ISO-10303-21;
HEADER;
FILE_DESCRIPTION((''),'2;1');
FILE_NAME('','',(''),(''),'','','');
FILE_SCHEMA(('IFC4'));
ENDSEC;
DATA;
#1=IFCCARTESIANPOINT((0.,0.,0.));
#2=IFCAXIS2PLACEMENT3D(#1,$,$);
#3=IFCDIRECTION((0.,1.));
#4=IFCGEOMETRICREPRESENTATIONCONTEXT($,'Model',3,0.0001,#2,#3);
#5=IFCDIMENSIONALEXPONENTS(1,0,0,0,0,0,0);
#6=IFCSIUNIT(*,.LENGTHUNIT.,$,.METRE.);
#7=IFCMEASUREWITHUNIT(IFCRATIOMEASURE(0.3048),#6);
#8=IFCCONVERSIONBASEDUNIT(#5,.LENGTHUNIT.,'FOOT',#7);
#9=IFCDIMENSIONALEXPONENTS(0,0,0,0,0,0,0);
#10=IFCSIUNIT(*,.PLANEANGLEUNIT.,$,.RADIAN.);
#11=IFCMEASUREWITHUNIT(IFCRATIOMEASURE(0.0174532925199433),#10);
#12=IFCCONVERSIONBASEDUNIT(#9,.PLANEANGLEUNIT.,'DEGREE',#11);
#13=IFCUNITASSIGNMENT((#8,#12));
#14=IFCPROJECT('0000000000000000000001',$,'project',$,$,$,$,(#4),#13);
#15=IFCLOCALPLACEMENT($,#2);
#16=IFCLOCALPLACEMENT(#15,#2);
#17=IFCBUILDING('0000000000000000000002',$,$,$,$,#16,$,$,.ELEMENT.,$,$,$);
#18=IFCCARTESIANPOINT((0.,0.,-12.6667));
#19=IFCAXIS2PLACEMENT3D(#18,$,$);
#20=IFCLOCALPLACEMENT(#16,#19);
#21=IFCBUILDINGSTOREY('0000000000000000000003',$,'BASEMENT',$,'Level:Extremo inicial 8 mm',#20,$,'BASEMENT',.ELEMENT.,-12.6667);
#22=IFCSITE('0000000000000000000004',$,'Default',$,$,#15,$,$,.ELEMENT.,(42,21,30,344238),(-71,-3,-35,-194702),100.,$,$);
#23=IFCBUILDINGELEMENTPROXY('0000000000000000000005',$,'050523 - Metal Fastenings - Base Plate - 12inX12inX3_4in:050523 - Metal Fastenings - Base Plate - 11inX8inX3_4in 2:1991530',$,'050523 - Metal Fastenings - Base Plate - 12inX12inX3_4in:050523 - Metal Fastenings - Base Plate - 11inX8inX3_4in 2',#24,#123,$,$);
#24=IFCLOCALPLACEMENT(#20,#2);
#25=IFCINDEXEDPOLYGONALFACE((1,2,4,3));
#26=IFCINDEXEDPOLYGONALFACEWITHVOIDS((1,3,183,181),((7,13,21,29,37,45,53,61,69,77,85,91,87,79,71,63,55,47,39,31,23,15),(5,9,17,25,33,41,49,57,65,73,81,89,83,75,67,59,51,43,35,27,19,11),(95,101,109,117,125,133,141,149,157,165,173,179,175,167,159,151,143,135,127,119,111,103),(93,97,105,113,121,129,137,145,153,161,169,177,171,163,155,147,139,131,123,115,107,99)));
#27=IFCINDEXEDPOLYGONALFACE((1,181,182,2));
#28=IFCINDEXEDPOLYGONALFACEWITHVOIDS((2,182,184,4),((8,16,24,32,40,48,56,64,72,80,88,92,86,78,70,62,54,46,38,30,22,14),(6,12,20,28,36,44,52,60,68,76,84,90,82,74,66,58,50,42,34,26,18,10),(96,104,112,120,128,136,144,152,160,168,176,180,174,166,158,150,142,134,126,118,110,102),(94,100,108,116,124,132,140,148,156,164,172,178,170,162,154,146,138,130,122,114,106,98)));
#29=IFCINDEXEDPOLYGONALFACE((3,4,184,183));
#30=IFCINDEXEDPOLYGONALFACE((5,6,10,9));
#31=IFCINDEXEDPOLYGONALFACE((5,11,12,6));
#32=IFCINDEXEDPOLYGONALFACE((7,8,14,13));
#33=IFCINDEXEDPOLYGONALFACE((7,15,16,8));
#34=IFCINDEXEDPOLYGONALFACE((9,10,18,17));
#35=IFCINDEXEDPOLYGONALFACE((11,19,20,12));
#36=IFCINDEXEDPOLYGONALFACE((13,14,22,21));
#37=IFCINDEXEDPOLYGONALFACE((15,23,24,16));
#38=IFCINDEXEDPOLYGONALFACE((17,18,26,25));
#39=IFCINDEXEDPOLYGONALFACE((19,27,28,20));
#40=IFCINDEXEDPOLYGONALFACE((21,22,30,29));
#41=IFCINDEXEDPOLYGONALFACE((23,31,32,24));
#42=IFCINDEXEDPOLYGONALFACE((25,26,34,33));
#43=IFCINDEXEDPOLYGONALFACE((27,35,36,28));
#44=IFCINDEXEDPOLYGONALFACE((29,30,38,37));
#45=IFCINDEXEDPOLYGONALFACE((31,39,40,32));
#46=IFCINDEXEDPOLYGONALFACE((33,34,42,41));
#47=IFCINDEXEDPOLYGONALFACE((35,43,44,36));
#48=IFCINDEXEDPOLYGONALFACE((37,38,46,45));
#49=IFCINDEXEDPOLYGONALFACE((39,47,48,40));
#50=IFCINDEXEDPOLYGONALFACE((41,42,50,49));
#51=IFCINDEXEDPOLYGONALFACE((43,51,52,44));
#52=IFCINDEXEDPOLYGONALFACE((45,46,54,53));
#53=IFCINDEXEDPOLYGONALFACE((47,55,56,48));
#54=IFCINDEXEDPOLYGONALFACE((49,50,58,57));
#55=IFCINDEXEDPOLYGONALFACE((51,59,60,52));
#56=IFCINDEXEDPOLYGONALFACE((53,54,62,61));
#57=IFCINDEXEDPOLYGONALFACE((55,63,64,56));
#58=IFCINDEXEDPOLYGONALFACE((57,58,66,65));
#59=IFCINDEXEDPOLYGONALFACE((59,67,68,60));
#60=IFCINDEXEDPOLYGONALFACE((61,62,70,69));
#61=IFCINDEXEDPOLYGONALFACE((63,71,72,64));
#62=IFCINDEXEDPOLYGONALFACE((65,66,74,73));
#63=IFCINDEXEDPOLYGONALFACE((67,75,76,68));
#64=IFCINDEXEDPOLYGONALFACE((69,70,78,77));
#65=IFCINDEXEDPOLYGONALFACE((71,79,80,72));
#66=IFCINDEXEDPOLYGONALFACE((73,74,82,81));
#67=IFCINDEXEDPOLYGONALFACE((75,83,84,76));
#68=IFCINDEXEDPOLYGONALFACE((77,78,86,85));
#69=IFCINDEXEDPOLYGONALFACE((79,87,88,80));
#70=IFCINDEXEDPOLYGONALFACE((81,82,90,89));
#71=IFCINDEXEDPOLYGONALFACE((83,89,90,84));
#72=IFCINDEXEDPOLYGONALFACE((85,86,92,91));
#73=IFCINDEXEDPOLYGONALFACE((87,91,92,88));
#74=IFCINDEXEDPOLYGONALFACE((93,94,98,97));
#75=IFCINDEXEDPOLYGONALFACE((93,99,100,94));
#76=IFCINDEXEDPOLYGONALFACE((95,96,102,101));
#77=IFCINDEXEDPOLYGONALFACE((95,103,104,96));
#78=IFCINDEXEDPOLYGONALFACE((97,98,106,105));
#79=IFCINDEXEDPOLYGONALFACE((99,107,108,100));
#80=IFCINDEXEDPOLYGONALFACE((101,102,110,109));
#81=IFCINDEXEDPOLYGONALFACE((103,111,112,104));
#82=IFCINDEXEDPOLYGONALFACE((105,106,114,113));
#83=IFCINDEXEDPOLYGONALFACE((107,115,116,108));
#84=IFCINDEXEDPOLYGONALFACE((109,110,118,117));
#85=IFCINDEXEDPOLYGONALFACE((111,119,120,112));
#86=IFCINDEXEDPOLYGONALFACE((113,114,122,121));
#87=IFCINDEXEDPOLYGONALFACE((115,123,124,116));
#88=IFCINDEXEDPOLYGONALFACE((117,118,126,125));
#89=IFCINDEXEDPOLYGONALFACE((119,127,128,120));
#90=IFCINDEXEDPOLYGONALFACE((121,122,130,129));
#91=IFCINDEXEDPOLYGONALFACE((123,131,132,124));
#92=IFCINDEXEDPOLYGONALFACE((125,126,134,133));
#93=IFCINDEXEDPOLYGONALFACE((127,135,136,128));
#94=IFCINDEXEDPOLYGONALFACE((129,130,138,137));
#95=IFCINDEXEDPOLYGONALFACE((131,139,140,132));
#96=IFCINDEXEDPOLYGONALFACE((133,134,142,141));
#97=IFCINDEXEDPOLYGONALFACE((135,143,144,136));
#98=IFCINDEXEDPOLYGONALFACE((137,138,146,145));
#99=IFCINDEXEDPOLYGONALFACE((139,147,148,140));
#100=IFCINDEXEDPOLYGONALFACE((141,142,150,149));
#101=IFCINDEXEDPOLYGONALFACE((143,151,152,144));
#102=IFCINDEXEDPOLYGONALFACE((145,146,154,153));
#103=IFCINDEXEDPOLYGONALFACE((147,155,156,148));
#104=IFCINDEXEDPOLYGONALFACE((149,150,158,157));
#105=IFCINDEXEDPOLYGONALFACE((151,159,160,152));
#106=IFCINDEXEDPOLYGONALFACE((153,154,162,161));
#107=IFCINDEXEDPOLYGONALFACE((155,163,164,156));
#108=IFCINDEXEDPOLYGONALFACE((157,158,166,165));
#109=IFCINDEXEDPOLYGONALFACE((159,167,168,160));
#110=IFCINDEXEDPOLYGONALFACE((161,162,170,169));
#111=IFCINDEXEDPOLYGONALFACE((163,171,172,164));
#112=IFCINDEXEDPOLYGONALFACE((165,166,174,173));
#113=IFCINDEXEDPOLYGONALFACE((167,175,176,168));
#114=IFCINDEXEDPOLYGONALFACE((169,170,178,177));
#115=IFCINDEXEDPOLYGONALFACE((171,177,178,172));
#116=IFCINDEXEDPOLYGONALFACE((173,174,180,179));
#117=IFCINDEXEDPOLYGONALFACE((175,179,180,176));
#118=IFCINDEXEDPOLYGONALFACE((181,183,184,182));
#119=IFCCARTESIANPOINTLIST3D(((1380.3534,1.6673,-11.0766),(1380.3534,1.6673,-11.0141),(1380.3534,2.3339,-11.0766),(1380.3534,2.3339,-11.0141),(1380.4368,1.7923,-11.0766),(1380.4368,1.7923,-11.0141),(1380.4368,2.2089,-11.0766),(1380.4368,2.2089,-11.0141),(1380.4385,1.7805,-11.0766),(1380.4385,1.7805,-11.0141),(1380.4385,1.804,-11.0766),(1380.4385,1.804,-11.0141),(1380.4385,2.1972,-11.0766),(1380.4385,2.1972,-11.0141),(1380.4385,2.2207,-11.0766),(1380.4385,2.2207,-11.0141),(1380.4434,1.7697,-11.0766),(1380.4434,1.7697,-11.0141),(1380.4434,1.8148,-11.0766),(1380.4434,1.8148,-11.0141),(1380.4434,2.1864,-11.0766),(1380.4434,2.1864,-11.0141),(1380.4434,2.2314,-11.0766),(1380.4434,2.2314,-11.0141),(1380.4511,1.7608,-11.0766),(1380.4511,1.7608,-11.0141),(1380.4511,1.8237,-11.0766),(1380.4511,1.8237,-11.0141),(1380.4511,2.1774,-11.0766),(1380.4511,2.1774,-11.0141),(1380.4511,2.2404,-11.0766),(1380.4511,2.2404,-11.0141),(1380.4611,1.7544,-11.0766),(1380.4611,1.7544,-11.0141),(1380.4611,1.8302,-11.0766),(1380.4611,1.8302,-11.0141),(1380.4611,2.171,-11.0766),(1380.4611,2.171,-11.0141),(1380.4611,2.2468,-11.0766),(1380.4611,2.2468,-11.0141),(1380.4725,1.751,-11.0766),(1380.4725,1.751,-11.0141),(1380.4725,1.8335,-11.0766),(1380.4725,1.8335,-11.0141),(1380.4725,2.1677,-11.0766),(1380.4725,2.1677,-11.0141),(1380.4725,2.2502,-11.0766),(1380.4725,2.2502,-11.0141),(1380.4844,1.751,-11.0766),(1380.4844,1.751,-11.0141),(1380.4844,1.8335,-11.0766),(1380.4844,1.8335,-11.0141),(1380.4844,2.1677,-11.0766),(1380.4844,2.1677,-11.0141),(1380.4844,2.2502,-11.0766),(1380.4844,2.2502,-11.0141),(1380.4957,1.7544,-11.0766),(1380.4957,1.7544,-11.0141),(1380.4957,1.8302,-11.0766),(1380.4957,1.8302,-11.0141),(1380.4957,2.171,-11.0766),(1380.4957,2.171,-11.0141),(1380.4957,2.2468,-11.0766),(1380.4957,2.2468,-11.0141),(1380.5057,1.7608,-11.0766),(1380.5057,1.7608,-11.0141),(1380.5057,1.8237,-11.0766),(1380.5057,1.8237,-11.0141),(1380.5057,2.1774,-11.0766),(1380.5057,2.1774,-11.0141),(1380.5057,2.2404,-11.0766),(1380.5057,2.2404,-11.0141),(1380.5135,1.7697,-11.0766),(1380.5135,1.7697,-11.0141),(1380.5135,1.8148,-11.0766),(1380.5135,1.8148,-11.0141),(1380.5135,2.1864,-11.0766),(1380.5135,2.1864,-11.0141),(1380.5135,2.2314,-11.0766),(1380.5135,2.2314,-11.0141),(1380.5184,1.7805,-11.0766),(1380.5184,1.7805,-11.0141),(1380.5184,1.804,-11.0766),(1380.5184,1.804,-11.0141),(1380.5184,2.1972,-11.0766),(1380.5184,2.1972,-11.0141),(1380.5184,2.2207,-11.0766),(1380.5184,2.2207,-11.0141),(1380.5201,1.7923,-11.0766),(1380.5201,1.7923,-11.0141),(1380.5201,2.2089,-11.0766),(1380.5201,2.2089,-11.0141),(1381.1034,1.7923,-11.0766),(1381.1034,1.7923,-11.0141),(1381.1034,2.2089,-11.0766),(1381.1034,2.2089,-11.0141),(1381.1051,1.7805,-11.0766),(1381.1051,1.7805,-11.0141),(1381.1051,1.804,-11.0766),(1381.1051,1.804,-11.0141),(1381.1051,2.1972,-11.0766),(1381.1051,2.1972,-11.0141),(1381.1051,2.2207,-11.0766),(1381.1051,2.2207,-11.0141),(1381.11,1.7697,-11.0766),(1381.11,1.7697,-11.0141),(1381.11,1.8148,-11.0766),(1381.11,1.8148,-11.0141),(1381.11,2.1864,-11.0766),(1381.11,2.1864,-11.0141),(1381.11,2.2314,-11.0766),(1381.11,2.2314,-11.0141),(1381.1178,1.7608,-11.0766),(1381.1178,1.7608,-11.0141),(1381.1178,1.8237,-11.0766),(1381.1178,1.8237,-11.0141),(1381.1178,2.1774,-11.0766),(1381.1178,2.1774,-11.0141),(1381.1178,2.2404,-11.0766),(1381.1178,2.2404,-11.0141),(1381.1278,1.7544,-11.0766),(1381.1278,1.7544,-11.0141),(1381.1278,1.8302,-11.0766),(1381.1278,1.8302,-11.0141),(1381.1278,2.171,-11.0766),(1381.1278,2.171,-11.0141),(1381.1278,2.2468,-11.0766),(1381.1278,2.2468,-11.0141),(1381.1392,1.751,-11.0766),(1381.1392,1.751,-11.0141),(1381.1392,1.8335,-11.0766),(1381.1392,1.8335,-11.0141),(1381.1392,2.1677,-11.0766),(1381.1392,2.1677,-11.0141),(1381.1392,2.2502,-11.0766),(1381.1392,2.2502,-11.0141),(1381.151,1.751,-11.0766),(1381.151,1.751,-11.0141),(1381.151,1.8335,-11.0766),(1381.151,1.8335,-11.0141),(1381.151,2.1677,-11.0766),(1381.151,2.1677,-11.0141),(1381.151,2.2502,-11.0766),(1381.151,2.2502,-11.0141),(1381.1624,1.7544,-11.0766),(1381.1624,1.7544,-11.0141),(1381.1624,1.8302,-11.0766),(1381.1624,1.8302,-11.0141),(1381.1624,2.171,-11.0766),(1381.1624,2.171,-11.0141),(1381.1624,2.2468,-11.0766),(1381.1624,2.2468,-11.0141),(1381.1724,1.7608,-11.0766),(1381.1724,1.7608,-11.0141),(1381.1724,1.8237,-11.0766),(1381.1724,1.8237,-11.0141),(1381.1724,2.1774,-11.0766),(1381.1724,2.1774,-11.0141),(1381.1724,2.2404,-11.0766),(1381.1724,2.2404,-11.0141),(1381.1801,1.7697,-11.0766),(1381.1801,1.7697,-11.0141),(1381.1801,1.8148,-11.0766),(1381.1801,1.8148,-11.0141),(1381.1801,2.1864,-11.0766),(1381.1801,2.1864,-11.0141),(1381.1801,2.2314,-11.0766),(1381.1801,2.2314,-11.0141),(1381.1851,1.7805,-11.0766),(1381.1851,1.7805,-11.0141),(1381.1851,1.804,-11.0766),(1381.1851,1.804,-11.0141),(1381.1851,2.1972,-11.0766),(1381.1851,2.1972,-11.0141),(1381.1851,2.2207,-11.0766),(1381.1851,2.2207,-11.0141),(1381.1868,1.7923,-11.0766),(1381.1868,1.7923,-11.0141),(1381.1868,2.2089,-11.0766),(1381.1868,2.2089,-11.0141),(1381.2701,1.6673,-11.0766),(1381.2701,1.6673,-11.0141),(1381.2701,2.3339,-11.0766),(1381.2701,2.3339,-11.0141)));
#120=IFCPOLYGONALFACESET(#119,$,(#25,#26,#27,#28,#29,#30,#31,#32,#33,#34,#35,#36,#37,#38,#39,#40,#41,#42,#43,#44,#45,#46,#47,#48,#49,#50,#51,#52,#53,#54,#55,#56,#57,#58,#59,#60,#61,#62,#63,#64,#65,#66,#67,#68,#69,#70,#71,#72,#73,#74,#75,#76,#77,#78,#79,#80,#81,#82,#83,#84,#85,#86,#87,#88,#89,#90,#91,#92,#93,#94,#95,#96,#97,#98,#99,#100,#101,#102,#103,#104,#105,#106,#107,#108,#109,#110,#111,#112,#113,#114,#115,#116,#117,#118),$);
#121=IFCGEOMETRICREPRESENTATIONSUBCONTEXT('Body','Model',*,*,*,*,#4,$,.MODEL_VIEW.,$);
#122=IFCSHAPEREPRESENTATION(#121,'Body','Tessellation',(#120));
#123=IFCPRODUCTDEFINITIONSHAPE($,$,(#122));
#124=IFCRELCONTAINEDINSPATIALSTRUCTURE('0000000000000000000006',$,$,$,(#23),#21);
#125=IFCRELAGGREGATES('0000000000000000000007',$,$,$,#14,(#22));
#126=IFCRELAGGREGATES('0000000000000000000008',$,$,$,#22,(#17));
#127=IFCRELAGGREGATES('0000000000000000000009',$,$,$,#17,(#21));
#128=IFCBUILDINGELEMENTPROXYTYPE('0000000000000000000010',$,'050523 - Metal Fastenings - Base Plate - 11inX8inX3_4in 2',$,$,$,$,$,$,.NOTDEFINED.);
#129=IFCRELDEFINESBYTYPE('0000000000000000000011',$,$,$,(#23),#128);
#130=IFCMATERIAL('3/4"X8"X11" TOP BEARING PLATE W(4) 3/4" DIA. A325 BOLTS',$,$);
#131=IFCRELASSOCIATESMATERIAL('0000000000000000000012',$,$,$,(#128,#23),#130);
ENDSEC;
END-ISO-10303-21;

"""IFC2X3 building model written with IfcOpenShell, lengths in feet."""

from ifc_helpers import new_model, entity, si_unit, converted_unit, direction, frame, frame_2d, origin, place, context, subcontext, project, spatial, polyline, circle_curve, parameter, trimmed, segment, composite_curve, outline, extrude, source, transform, mapped, material, type_object, type_shapes, element, save


model = new_model("IFC2X3")

# Units and contexts
model_context = context("Model", 3, precision=0.0001, world=origin(), true_north=direction((0.0, 1.0)))
body_context = subcontext(model_context, "Body", "Model", "MODEL_VIEW")
ifc_project = project(units=[converted_unit("LENGTHUNIT", "FOOT", entity("IfcRatioMeasure", 0.3048), si_unit("LENGTHUNIT", "METRE"), dimensions=[1, 0, 0, 0, 0, 0, 0]), converted_unit("PLANEANGLEUNIT", "DEGREE", entity("IfcRatioMeasure", 0.0174532925199433), si_unit("PLANEANGLEUNIT", "RADIAN"), dimensions=[0, 0, 0, 0, 0, 0, 0])], contexts=[model_context])

# Site, building, storey
site_placement = place(None, origin())
site = spatial("IfcSite", under=ifc_project, at=site_placement, Name="Default", CompositionType="ELEMENT", RefLatitude=(42, 21, 30, 344238), RefLongitude=(-71, -3, -35, -194702), RefElevation=100.0)
building_placement = place(site_placement, origin())
building = spatial("IfcBuilding", under=site, at=building_placement, CompositionType="ELEMENT")
storey_placement = place(building_placement, frame((0.0, 0.0, -12.6667)))
storey = spatial("IfcBuildingStorey", under=building, at=storey_placement, Name="BASEMENT", ObjectType="Level:Extremo inicial 8 mm", LongName="BASEMENT", CompositionType="ELEMENT", Elevation=-12.6667)

# Building element proxy
ifc_material_1 = material(Name="3/4\"X8\"X11\" TOP BEARING PLATE W(4) 3/4\" DIA. A325 BOLTS")
building_element_proxy_type_1 = type_object("IfcBuildingElementProxyType", Name="050523 - Metal Fastenings - Base Plate - 11inX8inX3_4in 2", PredefinedType="NOTDEFINED", material=ifc_material_1)
shared_shape_1 = source(origin(), body_context, "Body", "SweptSolid", [
    extrude(outline(polyline([(-0.4583, -0.3333), (0.4583, -0.3333), (0.4583, 0.3333), (-0.4583, 0.3333), (-0.4583, -0.3333)]), holes=[composite_curve([segment(trimmed(circle_curve(frame_2d((-0.3333, -0.2083), x_axis=(-1.0, 0.0)), 0.0417), [parameter(180.0)], [parameter(0.0)], True, "PARAMETER"), False, "CONTINUOUS"), segment(trimmed(circle_curve(frame_2d((-0.3333, -0.2083), x_axis=(-1.0, 0.0)), 0.0417), [parameter(0.0)], [parameter(180.0)], True, "PARAMETER"), False, "CONTINUOUS")], self_intersect=False), composite_curve([segment(trimmed(circle_curve(frame_2d((0.3333, -0.2083), x_axis=(-1.0, 0.0)), 0.0417), [parameter(180.0)], [parameter(0.0)], True, "PARAMETER"), False, "CONTINUOUS"), segment(trimmed(circle_curve(frame_2d((0.3333, -0.2083), x_axis=(-1.0, 0.0)), 0.0417), [parameter(0.0)], [parameter(180.0)], True, "PARAMETER"), False, "CONTINUOUS")], self_intersect=False), composite_curve([segment(trimmed(circle_curve(frame_2d((-0.3333, 0.2083), x_axis=(-1.0, 0.0)), 0.0417), [parameter(180.0)], [parameter(0.0)], True, "PARAMETER"), False, "CONTINUOUS"), segment(trimmed(circle_curve(frame_2d((-0.3333, 0.2083), x_axis=(-1.0, 0.0)), 0.0417), [parameter(0.0)], [parameter(180.0)], True, "PARAMETER"), False, "CONTINUOUS")], self_intersect=False), composite_curve([segment(trimmed(circle_curve(frame_2d((0.3333, 0.2083), x_axis=(-1.0, 0.0)), 0.0417), [parameter(180.0)], [parameter(0.0)], True, "PARAMETER"), False, "CONTINUOUS"), segment(trimmed(circle_curve(frame_2d((0.3333, 0.2083), x_axis=(-1.0, 0.0)), 0.0417), [parameter(0.0)], [parameter(180.0)], True, "PARAMETER"), False, "CONTINUOUS")], self_intersect=False)]), frame((0.0, 0.0, 0.0), z_axis=(0.0, 0.0, 1.0), x_axis=(-1.0, 0.0, 0.0)), (0.0, 0.0, 1.0), 0.0625),
])
type_shapes(building_element_proxy_type_1, [shared_shape_1])
proxy_1_placement = place(storey_placement, frame((1380.8118, 2.0006, -11.0766)))
element("IfcBuildingElementProxy", 1, at=proxy_1_placement, inside=storey, type_object=building_element_proxy_type_1, material=ifc_material_1, Name="050523 - Metal Fastenings - Base Plate - 12inX12inX3_4in:050523 - Metal Fastenings - Base Plate - 11inX8inX3_4in 2:1991530", ObjectType="050523 - Metal Fastenings - Base Plate - 12inX12inX3_4in:050523 - Metal Fastenings - Base Plate - 11inX8inX3_4in 2", context=body_context, shape_type="MappedRepresentation", body=[
    mapped(shared_shape_1, transform((0.0, 0.0, 0.0), scale=1.0)),
])

save(model, "model.ifc")
